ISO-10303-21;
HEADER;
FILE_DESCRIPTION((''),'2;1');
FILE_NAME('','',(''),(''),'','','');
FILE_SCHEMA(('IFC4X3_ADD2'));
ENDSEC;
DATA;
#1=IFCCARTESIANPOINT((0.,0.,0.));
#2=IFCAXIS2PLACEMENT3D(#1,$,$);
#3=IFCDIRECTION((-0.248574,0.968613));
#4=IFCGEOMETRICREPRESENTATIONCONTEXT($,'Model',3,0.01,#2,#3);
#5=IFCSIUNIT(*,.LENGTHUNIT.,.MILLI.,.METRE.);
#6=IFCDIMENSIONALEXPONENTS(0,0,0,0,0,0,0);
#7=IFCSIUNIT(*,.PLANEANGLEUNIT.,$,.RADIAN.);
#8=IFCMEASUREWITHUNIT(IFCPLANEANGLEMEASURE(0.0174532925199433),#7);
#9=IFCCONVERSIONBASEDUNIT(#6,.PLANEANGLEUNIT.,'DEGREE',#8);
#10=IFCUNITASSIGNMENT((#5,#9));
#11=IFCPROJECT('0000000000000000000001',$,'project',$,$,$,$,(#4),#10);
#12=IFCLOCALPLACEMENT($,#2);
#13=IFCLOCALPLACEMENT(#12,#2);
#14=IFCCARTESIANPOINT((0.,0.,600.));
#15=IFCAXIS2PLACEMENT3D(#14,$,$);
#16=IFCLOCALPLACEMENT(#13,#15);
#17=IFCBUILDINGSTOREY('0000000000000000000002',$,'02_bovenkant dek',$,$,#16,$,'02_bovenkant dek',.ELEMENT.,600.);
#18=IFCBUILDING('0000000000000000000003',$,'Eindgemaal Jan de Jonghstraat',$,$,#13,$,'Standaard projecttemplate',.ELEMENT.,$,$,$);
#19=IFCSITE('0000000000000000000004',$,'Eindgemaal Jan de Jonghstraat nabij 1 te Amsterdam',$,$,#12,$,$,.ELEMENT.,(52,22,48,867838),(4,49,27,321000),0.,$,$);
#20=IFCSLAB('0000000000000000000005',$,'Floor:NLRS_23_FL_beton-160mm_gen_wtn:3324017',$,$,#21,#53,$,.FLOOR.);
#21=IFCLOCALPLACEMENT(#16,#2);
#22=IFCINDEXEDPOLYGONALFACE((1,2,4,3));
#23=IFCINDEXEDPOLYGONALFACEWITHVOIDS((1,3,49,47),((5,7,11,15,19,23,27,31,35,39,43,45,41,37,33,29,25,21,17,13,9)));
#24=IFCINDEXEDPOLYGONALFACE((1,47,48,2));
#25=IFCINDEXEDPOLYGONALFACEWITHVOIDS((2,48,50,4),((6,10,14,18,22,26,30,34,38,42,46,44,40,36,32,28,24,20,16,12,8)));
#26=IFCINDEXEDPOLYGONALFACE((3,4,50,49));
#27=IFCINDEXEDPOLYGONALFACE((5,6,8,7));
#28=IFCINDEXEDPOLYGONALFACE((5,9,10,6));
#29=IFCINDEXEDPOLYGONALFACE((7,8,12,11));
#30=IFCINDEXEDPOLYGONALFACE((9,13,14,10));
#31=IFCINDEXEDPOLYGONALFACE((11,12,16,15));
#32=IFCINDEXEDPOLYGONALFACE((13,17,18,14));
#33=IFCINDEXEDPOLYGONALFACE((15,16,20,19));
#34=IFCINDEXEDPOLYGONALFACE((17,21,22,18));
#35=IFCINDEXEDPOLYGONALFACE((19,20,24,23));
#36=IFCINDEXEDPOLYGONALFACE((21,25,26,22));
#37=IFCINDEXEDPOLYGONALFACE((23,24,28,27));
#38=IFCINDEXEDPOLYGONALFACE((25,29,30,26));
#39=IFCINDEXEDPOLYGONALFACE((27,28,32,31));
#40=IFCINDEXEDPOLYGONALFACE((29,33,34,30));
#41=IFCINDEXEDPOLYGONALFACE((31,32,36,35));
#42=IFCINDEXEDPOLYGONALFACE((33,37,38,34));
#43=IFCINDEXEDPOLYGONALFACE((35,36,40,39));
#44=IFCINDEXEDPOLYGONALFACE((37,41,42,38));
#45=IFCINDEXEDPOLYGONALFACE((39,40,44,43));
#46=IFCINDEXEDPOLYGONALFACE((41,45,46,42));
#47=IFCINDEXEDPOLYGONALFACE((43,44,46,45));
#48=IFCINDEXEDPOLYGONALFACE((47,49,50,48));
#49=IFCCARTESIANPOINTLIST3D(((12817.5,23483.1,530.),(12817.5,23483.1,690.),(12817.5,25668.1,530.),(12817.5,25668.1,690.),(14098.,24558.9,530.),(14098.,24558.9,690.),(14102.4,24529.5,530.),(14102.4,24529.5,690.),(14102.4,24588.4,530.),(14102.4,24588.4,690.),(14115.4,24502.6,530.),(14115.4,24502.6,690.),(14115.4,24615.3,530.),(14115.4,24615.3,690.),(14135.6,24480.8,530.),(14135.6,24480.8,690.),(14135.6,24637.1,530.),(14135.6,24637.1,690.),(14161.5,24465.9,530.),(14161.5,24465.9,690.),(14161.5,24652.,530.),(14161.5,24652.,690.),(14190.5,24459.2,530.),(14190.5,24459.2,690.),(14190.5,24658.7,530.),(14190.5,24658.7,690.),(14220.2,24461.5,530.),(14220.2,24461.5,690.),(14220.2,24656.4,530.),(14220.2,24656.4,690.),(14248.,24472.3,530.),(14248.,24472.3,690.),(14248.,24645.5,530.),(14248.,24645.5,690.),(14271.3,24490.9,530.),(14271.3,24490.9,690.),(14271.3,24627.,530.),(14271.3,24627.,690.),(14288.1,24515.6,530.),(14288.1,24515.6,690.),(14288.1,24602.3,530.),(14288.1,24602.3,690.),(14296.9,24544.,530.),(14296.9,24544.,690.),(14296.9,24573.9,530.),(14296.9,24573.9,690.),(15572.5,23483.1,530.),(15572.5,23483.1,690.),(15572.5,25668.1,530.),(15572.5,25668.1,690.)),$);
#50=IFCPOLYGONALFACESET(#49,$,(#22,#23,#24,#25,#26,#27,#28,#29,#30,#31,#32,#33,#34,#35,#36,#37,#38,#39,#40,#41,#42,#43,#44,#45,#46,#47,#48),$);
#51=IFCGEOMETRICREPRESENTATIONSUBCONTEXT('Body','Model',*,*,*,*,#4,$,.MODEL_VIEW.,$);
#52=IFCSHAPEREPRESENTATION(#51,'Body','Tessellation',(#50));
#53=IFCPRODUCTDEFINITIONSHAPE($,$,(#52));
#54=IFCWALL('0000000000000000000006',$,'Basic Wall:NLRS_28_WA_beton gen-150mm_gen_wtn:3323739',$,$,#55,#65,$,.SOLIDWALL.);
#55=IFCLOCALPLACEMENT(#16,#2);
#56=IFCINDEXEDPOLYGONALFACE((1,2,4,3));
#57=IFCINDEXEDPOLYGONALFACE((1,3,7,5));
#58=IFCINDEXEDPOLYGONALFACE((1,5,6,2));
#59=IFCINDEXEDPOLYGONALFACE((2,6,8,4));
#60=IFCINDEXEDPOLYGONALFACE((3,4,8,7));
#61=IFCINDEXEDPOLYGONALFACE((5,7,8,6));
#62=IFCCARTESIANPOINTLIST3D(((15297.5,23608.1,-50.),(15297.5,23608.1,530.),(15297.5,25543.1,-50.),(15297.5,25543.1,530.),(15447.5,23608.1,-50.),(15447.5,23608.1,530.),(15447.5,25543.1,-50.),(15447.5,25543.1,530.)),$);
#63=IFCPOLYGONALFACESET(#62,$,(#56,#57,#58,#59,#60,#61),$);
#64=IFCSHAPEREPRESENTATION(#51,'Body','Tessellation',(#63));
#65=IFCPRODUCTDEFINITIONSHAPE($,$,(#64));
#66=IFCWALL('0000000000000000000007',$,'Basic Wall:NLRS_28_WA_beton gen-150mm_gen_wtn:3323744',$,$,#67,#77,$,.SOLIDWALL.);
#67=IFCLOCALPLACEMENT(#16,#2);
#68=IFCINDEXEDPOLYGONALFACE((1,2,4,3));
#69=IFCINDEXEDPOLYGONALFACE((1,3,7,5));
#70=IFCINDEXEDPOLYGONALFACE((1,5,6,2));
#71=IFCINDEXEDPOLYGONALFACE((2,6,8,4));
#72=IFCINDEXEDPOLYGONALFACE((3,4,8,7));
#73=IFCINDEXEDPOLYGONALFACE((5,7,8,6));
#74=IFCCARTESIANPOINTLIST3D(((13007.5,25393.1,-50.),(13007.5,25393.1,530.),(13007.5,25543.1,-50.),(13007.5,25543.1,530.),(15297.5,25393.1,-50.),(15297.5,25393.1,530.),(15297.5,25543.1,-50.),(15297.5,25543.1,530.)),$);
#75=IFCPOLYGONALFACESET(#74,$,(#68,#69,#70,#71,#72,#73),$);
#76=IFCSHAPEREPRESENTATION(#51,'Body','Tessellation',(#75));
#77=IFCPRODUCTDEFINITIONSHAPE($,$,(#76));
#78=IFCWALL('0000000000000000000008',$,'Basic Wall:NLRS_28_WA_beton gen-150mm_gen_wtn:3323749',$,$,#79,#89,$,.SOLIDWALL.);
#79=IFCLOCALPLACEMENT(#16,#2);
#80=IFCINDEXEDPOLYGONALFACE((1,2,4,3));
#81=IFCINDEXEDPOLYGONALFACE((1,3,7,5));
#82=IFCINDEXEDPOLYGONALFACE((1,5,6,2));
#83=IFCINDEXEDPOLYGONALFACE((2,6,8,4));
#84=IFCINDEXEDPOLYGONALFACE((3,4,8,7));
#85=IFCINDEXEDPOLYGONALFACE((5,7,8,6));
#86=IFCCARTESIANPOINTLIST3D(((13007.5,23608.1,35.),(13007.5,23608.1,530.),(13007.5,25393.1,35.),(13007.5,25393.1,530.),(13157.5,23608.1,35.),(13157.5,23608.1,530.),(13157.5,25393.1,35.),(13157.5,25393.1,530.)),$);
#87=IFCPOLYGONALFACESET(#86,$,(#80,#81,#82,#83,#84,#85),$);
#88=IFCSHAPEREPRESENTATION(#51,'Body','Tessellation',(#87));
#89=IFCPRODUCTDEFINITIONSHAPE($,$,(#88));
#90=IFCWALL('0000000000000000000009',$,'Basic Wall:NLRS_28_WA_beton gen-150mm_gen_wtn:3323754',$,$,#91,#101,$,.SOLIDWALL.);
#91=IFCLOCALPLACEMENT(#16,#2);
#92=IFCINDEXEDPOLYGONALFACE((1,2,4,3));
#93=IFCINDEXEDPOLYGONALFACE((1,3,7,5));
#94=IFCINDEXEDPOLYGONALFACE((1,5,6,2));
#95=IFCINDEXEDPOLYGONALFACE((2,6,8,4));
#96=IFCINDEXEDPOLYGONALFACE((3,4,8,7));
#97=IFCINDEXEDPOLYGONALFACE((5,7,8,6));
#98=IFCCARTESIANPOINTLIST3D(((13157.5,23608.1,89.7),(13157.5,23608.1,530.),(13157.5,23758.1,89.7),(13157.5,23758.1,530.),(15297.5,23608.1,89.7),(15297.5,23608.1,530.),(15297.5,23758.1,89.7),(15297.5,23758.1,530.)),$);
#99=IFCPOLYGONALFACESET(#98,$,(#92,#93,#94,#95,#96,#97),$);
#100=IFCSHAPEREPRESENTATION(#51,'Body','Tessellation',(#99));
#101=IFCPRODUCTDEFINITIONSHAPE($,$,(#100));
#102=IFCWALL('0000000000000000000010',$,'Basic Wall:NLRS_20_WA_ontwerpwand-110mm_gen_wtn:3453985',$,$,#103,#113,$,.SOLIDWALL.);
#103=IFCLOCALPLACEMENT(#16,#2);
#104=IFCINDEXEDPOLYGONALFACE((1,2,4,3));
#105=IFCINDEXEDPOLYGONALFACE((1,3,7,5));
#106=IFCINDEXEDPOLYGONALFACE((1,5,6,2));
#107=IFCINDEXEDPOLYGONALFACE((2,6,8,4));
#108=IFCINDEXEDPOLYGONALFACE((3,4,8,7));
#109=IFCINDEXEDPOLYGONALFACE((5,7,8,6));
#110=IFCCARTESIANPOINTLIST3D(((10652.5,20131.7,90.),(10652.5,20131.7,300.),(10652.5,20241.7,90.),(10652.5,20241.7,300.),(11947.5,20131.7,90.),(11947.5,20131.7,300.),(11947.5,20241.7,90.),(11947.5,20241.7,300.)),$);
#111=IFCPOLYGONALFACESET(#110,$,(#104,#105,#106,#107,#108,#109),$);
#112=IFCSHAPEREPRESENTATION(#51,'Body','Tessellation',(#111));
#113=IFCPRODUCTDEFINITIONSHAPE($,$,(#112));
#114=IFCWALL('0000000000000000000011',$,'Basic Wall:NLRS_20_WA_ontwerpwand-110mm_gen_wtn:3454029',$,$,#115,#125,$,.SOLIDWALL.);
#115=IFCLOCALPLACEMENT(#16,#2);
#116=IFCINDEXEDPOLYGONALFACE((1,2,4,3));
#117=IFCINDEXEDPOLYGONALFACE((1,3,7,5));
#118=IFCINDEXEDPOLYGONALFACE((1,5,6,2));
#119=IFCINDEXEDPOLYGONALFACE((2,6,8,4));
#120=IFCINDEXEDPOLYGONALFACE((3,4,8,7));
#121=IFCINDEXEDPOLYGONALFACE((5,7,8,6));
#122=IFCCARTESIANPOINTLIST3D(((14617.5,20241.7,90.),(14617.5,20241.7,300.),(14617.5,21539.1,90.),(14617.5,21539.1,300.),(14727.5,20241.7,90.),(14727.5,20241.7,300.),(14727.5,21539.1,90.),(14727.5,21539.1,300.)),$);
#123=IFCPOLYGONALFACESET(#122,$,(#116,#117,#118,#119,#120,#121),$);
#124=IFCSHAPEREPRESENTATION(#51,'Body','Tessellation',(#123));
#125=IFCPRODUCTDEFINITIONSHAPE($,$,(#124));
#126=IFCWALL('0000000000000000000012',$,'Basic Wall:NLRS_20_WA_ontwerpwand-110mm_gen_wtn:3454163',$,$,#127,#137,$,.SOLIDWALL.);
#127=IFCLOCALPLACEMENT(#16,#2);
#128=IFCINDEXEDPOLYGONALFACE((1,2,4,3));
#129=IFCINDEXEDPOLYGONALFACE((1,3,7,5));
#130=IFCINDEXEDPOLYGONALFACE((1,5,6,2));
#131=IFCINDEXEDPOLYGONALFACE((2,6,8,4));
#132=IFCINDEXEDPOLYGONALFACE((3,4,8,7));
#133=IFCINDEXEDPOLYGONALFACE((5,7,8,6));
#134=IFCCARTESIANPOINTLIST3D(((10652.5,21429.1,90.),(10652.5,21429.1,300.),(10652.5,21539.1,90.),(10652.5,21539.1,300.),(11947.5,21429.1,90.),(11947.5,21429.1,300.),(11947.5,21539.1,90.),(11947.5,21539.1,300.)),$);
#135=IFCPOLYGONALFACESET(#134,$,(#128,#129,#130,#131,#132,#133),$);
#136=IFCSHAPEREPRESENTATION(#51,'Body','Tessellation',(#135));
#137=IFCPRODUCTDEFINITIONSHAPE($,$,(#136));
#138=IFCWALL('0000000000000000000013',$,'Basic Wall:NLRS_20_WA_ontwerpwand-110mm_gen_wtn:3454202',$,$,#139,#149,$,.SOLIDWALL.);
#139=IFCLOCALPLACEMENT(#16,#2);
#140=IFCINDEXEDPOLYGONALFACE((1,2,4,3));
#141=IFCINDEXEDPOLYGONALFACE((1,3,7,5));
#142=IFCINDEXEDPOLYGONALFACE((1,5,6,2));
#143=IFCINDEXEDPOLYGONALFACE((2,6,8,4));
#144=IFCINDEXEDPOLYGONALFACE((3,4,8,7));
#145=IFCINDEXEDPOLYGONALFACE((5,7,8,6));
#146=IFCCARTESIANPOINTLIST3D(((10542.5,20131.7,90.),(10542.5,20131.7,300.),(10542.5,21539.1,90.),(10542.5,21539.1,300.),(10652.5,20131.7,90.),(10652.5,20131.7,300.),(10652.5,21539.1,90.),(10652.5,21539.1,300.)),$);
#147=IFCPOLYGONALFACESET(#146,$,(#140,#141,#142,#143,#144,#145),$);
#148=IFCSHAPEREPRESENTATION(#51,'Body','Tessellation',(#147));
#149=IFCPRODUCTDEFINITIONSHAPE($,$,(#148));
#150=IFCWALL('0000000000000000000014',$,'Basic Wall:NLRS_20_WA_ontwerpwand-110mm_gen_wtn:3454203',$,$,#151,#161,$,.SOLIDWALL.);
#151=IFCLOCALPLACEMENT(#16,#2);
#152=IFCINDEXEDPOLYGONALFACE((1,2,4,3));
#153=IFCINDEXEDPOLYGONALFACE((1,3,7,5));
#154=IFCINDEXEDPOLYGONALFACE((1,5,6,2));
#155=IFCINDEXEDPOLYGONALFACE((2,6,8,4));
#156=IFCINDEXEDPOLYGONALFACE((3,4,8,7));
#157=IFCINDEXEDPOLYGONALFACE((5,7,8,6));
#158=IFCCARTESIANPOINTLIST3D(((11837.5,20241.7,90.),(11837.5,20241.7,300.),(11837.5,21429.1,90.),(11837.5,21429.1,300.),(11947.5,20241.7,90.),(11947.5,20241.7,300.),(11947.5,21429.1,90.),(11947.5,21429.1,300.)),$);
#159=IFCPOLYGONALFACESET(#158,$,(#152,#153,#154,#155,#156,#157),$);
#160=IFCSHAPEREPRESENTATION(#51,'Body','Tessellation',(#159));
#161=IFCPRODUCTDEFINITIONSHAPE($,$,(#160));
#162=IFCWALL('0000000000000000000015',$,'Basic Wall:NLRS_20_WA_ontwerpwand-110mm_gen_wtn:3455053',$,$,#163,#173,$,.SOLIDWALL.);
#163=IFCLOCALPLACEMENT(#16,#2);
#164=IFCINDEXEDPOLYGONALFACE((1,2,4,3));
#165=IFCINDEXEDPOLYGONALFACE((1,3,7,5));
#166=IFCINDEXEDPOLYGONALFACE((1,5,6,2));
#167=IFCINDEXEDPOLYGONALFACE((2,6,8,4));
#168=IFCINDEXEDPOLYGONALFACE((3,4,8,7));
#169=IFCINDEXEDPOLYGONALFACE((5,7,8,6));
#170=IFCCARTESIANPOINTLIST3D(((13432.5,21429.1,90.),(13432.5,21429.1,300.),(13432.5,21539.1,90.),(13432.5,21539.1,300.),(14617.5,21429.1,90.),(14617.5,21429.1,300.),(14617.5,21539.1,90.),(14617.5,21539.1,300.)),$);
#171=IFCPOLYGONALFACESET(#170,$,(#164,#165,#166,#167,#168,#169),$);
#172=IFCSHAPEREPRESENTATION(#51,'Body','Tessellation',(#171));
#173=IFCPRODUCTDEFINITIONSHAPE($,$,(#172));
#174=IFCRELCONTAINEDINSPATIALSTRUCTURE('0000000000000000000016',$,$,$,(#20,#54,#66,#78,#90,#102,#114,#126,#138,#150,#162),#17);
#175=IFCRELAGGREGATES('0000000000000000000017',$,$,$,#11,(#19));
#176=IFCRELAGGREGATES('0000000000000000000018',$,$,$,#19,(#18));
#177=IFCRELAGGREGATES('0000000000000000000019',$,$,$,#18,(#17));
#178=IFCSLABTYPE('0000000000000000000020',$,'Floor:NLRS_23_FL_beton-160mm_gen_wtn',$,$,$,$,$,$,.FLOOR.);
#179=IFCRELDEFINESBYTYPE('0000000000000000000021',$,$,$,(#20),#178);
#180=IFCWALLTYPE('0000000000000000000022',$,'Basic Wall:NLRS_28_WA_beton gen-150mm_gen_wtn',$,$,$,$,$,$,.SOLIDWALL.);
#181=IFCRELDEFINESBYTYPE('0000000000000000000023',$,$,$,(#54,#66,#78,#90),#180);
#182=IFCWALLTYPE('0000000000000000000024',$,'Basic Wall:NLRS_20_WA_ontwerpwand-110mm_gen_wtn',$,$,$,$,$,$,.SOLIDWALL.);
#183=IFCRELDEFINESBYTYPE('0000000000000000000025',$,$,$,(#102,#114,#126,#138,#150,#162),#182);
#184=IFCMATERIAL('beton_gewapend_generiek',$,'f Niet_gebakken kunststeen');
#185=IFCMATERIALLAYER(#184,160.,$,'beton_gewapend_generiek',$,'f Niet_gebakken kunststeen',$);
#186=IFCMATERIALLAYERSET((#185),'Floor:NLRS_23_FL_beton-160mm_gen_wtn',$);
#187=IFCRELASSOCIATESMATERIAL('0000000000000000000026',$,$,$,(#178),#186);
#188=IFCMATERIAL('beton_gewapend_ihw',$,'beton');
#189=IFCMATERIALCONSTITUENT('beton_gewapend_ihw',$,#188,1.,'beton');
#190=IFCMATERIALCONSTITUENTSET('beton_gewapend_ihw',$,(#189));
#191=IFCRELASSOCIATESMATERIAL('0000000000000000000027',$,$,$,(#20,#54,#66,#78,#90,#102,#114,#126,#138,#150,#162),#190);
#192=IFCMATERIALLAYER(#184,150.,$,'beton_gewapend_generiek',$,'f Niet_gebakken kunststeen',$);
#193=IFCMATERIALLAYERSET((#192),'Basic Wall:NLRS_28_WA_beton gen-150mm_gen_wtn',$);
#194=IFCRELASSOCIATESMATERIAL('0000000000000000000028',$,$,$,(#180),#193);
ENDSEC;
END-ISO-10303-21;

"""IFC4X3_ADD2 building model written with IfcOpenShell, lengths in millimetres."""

from ifc_helpers import new_model, entity, si_unit, converted_unit, direction, frame, frame_2d, origin, origin_2d_with_axis, place, context, subcontext, project, spatial, rectangle, circle, extrude, material, layer, layer_set, constituent, constituent_set, type_object, element, save


model = new_model("IFC4X3_ADD2")

# Units and contexts
model_context = context("Model", 3, precision=0.01, world=origin(), true_north=direction((-0.248574, 0.968613)))
body_context = subcontext(model_context, "Body", "Model", "MODEL_VIEW")
ifc_project = project(units=[si_unit("LENGTHUNIT", "METRE", prefix="MILLI"), converted_unit("PLANEANGLEUNIT", "DEGREE", entity("IfcPlaneAngleMeasure", 0.0174532925199433), si_unit("PLANEANGLEUNIT", "RADIAN"), dimensions=[0, 0, 0, 0, 0, 0, 0])], contexts=[model_context])

# Site, building, storey
site_placement = place(None, origin())
site = spatial("IfcSite", under=ifc_project, at=site_placement, Name="Eindgemaal Jan de Jonghstraat nabij 1 te Amsterdam", CompositionType="ELEMENT", RefLatitude=(52, 22, 48, 867838), RefLongitude=(4, 49, 27, 321000), RefElevation=0.0)
building_placement = place(site_placement, origin())
building = spatial("IfcBuilding", under=site, at=building_placement, Name="Eindgemaal Jan de Jonghstraat", LongName="Standaard projecttemplate", CompositionType="ELEMENT")
storey_placement = place(building_placement, frame((0.0, 0.0, 600.0)))
storey = spatial("IfcBuildingStorey", under=building, at=storey_placement, Name="02_bovenkant dek", LongName="02_bovenkant dek", CompositionType="ELEMENT", Elevation=600.0)

# Slab, opening
ifc_material_1 = material(Name="beton_gewapend_ihw", Category="beton")
ifc_constituent_1 = constituent(ifc_material_1, Name="beton_gewapend_ihw", Category="beton", fraction=1.0)
ifc_constituent_set_1 = constituent_set(constituents=[ifc_constituent_1], Name="beton_gewapend_ihw")
ifc_material_2 = material(Name="beton_gewapend_generiek", Category="f Niet_gebakken kunststeen")
ifc_layer_1 = layer(ifc_material_2, 160.0, Name="beton_gewapend_generiek", Category="f Niet_gebakken kunststeen")
ifc_layer_set_1 = layer_set([ifc_layer_1], Name="Floor:NLRS_23_FL_beton-160mm_gen_wtn")
slab_type = type_object("IfcSlabType", Name="Floor:NLRS_23_FL_beton-160mm_gen_wtn", PredefinedType="FLOOR", material=ifc_layer_set_1)
slab_placement = place(storey_placement, frame((12817.5, 23483.1, 530.0)))
slab = element("IfcSlab", 1, at=slab_placement, inside=storey, type_object=slab_type, material=ifc_constituent_set_1, Name="Floor:NLRS_23_FL_beton-160mm_gen_wtn:3324017", PredefinedType="FLOOR", context=body_context, shape_type="SweptSolid", body=[
    extrude(rectangle(XDim=2755.0, YDim=2185.0, at=origin_2d_with_axis()), frame((1377.5, 1092.5, 160.0), z_axis=(0.0, 0.0, -1.0), x_axis=(-1.0, 0.0, 0.0)), (0.0, 0.0, 1.0), 160.0),
])
opening_placement = place(slab_placement, origin())
element("IfcOpeningElement", 2, at=opening_placement, cuts=slab, PredefinedType="OPENING", context=body_context, shape_type="SweptSolid", body=[
    extrude(circle(Radius=100.0, at=frame_2d((-3.0, -16.6), x_axis=(1.0, 0.0))), frame((1377.5, 1092.5, 160.0), z_axis=(0.0, 0.0, -1.0), x_axis=(-1.0, 0.0, 0.0)), (0.0, 0.0, 1.0), 160.0),
])

# Walls
ifc_layer_2 = layer(ifc_material_2, 150.0, Name="beton_gewapend_generiek", Category="f Niet_gebakken kunststeen")
ifc_layer_set_2 = layer_set([ifc_layer_2], Name="Basic Wall:NLRS_28_WA_beton gen-150mm_gen_wtn")
wall_type_1 = type_object("IfcWallType", Name="Basic Wall:NLRS_28_WA_beton gen-150mm_gen_wtn", PredefinedType="SOLIDWALL", material=ifc_layer_set_2)
wall_1_placement = place(storey_placement, frame((15372.5, 23608.1, -50.0), z_axis=(0.0, 0.0, 1.0), x_axis=(0.0, 1.0, 0.0)))
element("IfcWall", 3, at=wall_1_placement, inside=storey, type_object=wall_type_1, material=ifc_constituent_set_1, Name="Basic Wall:NLRS_28_WA_beton gen-150mm_gen_wtn:3323739", PredefinedType="SOLIDWALL", context=body_context, shape_type="SweptSolid", body=[
    extrude(rectangle(XDim=1935.0, YDim=150.0, at=frame_2d((967.5, 0.0), x_axis=(-1.0, 0.0))), origin(), (0.0, 0.0, 1.0), 580.0),
])
wall_2_placement = place(storey_placement, frame((15297.5, 25468.1, -50.0), z_axis=(0.0, 0.0, 1.0), x_axis=(-1.0, 0.0, 0.0)))
element("IfcWall", 4, at=wall_2_placement, inside=storey, type_object=wall_type_1, material=ifc_constituent_set_1, Name="Basic Wall:NLRS_28_WA_beton gen-150mm_gen_wtn:3323744", PredefinedType="SOLIDWALL", context=body_context, shape_type="SweptSolid", body=[
    extrude(rectangle(XDim=2290.0, YDim=150.0, at=frame_2d((1145.0, 0.0), x_axis=(-1.0, 0.0))), origin(), (0.0, 0.0, 1.0), 580.0),
])
wall_3_placement = place(storey_placement, frame((13082.5, 23608.1, 35.0), z_axis=(0.0, 0.0, 1.0), x_axis=(0.0, 1.0, 0.0)))
element("IfcWall", 5, at=wall_3_placement, inside=storey, type_object=wall_type_1, material=ifc_constituent_set_1, Name="Basic Wall:NLRS_28_WA_beton gen-150mm_gen_wtn:3323749", PredefinedType="SOLIDWALL", context=body_context, shape_type="SweptSolid", body=[
    extrude(rectangle(XDim=1785.0, YDim=150.0, at=frame_2d((892.5, 0.0), x_axis=(-1.0, 0.0))), origin(), (0.0, 0.0, 1.0), 495.0),
])
wall_4_placement = place(storey_placement, frame((15297.5, 23683.1, 89.7), z_axis=(0.0, 0.0, 1.0), x_axis=(-1.0, 0.0, 0.0)))
element("IfcWall", 6, at=wall_4_placement, inside=storey, type_object=wall_type_1, material=ifc_constituent_set_1, Name="Basic Wall:NLRS_28_WA_beton gen-150mm_gen_wtn:3323754", PredefinedType="SOLIDWALL", context=body_context, shape_type="SweptSolid", body=[
    extrude(rectangle(XDim=2140.0, YDim=150.0, at=frame_2d((1070.0, 0.0), x_axis=(-1.0, 0.0))), origin(), (0.0, 0.0, 1.0), 440.3),
])
wall_type_2 = type_object("IfcWallType", Name="Basic Wall:NLRS_20_WA_ontwerpwand-110mm_gen_wtn", PredefinedType="SOLIDWALL")
wall_5_placement = place(storey_placement, frame((10652.5, 20186.7, 90.0)))
element("IfcWall", 7, at=wall_5_placement, inside=storey, type_object=wall_type_2, material=ifc_constituent_set_1, Name="Basic Wall:NLRS_20_WA_ontwerpwand-110mm_gen_wtn:3453985", PredefinedType="SOLIDWALL", context=body_context, shape_type="SweptSolid", body=[
    extrude(rectangle(XDim=1295.0, YDim=110.0, at=frame_2d((647.5, 0.0), x_axis=(-1.0, 0.0))), origin(), (0.0, 0.0, 1.0), 210.0),
])
wall_6_placement = place(storey_placement, frame((14672.5, 20241.7, 90.0), z_axis=(0.0, 0.0, 1.0), x_axis=(0.0, 1.0, 0.0)))
element("IfcWall", 8, at=wall_6_placement, inside=storey, type_object=wall_type_2, material=ifc_constituent_set_1, Name="Basic Wall:NLRS_20_WA_ontwerpwand-110mm_gen_wtn:3454029", PredefinedType="SOLIDWALL", context=body_context, shape_type="SweptSolid", body=[
    extrude(rectangle(XDim=1297.3, YDim=110.0, at=frame_2d((648.7, 0.0), x_axis=(-1.0, 0.0))), origin(), (0.0, 0.0, 1.0), 210.0),
])
wall_7_placement = place(storey_placement, frame((10652.5, 21484.1, 90.0)))
element("IfcWall", 9, at=wall_7_placement, inside=storey, type_object=wall_type_2, material=ifc_constituent_set_1, Name="Basic Wall:NLRS_20_WA_ontwerpwand-110mm_gen_wtn:3454163", PredefinedType="SOLIDWALL", context=body_context, shape_type="SweptSolid", body=[
    extrude(rectangle(XDim=1295.0, YDim=110.0, at=frame_2d((647.5, 0.0), x_axis=(-1.0, 0.0))), origin(), (0.0, 0.0, 1.0), 210.0),
])
wall_8_placement = place(storey_placement, frame((10597.5, 20131.7, 90.0), z_axis=(0.0, 0.0, 1.0), x_axis=(0.0, 1.0, 0.0)))
element("IfcWall", 10, at=wall_8_placement, inside=storey, type_object=wall_type_2, material=ifc_constituent_set_1, Name="Basic Wall:NLRS_20_WA_ontwerpwand-110mm_gen_wtn:3454202", PredefinedType="SOLIDWALL", context=body_context, shape_type="SweptSolid", body=[
    extrude(rectangle(XDim=1407.3, YDim=110.0, at=frame_2d((703.7, 0.0), x_axis=(-1.0, 0.0))), origin(), (0.0, 0.0, 1.0), 210.0),
])
wall_9_placement = place(storey_placement, frame((11892.5, 20241.7, 90.0), z_axis=(0.0, 0.0, 1.0), x_axis=(0.0, 1.0, 0.0)))
element("IfcWall", 11, at=wall_9_placement, inside=storey, type_object=wall_type_2, material=ifc_constituent_set_1, Name="Basic Wall:NLRS_20_WA_ontwerpwand-110mm_gen_wtn:3454203", PredefinedType="SOLIDWALL", context=body_context, shape_type="SweptSolid", body=[
    extrude(rectangle(XDim=1187.3, YDim=110.0, at=frame_2d((593.7, 0.0), x_axis=(-1.0, 0.0))), origin(), (0.0, 0.0, 1.0), 210.0),
])
wall_10_placement = place(storey_placement, frame((13432.5, 21484.1, 90.0)))
element("IfcWall", 12, at=wall_10_placement, inside=storey, type_object=wall_type_2, material=ifc_constituent_set_1, Name="Basic Wall:NLRS_20_WA_ontwerpwand-110mm_gen_wtn:3455053", PredefinedType="SOLIDWALL", context=body_context, shape_type="SweptSolid", body=[
    extrude(rectangle(XDim=1185.0, YDim=110.0, at=frame_2d((592.5, 0.0), x_axis=(-1.0, 0.0))), origin(), (0.0, 0.0, 1.0), 210.0),
])

save(model, "model.ifc")
